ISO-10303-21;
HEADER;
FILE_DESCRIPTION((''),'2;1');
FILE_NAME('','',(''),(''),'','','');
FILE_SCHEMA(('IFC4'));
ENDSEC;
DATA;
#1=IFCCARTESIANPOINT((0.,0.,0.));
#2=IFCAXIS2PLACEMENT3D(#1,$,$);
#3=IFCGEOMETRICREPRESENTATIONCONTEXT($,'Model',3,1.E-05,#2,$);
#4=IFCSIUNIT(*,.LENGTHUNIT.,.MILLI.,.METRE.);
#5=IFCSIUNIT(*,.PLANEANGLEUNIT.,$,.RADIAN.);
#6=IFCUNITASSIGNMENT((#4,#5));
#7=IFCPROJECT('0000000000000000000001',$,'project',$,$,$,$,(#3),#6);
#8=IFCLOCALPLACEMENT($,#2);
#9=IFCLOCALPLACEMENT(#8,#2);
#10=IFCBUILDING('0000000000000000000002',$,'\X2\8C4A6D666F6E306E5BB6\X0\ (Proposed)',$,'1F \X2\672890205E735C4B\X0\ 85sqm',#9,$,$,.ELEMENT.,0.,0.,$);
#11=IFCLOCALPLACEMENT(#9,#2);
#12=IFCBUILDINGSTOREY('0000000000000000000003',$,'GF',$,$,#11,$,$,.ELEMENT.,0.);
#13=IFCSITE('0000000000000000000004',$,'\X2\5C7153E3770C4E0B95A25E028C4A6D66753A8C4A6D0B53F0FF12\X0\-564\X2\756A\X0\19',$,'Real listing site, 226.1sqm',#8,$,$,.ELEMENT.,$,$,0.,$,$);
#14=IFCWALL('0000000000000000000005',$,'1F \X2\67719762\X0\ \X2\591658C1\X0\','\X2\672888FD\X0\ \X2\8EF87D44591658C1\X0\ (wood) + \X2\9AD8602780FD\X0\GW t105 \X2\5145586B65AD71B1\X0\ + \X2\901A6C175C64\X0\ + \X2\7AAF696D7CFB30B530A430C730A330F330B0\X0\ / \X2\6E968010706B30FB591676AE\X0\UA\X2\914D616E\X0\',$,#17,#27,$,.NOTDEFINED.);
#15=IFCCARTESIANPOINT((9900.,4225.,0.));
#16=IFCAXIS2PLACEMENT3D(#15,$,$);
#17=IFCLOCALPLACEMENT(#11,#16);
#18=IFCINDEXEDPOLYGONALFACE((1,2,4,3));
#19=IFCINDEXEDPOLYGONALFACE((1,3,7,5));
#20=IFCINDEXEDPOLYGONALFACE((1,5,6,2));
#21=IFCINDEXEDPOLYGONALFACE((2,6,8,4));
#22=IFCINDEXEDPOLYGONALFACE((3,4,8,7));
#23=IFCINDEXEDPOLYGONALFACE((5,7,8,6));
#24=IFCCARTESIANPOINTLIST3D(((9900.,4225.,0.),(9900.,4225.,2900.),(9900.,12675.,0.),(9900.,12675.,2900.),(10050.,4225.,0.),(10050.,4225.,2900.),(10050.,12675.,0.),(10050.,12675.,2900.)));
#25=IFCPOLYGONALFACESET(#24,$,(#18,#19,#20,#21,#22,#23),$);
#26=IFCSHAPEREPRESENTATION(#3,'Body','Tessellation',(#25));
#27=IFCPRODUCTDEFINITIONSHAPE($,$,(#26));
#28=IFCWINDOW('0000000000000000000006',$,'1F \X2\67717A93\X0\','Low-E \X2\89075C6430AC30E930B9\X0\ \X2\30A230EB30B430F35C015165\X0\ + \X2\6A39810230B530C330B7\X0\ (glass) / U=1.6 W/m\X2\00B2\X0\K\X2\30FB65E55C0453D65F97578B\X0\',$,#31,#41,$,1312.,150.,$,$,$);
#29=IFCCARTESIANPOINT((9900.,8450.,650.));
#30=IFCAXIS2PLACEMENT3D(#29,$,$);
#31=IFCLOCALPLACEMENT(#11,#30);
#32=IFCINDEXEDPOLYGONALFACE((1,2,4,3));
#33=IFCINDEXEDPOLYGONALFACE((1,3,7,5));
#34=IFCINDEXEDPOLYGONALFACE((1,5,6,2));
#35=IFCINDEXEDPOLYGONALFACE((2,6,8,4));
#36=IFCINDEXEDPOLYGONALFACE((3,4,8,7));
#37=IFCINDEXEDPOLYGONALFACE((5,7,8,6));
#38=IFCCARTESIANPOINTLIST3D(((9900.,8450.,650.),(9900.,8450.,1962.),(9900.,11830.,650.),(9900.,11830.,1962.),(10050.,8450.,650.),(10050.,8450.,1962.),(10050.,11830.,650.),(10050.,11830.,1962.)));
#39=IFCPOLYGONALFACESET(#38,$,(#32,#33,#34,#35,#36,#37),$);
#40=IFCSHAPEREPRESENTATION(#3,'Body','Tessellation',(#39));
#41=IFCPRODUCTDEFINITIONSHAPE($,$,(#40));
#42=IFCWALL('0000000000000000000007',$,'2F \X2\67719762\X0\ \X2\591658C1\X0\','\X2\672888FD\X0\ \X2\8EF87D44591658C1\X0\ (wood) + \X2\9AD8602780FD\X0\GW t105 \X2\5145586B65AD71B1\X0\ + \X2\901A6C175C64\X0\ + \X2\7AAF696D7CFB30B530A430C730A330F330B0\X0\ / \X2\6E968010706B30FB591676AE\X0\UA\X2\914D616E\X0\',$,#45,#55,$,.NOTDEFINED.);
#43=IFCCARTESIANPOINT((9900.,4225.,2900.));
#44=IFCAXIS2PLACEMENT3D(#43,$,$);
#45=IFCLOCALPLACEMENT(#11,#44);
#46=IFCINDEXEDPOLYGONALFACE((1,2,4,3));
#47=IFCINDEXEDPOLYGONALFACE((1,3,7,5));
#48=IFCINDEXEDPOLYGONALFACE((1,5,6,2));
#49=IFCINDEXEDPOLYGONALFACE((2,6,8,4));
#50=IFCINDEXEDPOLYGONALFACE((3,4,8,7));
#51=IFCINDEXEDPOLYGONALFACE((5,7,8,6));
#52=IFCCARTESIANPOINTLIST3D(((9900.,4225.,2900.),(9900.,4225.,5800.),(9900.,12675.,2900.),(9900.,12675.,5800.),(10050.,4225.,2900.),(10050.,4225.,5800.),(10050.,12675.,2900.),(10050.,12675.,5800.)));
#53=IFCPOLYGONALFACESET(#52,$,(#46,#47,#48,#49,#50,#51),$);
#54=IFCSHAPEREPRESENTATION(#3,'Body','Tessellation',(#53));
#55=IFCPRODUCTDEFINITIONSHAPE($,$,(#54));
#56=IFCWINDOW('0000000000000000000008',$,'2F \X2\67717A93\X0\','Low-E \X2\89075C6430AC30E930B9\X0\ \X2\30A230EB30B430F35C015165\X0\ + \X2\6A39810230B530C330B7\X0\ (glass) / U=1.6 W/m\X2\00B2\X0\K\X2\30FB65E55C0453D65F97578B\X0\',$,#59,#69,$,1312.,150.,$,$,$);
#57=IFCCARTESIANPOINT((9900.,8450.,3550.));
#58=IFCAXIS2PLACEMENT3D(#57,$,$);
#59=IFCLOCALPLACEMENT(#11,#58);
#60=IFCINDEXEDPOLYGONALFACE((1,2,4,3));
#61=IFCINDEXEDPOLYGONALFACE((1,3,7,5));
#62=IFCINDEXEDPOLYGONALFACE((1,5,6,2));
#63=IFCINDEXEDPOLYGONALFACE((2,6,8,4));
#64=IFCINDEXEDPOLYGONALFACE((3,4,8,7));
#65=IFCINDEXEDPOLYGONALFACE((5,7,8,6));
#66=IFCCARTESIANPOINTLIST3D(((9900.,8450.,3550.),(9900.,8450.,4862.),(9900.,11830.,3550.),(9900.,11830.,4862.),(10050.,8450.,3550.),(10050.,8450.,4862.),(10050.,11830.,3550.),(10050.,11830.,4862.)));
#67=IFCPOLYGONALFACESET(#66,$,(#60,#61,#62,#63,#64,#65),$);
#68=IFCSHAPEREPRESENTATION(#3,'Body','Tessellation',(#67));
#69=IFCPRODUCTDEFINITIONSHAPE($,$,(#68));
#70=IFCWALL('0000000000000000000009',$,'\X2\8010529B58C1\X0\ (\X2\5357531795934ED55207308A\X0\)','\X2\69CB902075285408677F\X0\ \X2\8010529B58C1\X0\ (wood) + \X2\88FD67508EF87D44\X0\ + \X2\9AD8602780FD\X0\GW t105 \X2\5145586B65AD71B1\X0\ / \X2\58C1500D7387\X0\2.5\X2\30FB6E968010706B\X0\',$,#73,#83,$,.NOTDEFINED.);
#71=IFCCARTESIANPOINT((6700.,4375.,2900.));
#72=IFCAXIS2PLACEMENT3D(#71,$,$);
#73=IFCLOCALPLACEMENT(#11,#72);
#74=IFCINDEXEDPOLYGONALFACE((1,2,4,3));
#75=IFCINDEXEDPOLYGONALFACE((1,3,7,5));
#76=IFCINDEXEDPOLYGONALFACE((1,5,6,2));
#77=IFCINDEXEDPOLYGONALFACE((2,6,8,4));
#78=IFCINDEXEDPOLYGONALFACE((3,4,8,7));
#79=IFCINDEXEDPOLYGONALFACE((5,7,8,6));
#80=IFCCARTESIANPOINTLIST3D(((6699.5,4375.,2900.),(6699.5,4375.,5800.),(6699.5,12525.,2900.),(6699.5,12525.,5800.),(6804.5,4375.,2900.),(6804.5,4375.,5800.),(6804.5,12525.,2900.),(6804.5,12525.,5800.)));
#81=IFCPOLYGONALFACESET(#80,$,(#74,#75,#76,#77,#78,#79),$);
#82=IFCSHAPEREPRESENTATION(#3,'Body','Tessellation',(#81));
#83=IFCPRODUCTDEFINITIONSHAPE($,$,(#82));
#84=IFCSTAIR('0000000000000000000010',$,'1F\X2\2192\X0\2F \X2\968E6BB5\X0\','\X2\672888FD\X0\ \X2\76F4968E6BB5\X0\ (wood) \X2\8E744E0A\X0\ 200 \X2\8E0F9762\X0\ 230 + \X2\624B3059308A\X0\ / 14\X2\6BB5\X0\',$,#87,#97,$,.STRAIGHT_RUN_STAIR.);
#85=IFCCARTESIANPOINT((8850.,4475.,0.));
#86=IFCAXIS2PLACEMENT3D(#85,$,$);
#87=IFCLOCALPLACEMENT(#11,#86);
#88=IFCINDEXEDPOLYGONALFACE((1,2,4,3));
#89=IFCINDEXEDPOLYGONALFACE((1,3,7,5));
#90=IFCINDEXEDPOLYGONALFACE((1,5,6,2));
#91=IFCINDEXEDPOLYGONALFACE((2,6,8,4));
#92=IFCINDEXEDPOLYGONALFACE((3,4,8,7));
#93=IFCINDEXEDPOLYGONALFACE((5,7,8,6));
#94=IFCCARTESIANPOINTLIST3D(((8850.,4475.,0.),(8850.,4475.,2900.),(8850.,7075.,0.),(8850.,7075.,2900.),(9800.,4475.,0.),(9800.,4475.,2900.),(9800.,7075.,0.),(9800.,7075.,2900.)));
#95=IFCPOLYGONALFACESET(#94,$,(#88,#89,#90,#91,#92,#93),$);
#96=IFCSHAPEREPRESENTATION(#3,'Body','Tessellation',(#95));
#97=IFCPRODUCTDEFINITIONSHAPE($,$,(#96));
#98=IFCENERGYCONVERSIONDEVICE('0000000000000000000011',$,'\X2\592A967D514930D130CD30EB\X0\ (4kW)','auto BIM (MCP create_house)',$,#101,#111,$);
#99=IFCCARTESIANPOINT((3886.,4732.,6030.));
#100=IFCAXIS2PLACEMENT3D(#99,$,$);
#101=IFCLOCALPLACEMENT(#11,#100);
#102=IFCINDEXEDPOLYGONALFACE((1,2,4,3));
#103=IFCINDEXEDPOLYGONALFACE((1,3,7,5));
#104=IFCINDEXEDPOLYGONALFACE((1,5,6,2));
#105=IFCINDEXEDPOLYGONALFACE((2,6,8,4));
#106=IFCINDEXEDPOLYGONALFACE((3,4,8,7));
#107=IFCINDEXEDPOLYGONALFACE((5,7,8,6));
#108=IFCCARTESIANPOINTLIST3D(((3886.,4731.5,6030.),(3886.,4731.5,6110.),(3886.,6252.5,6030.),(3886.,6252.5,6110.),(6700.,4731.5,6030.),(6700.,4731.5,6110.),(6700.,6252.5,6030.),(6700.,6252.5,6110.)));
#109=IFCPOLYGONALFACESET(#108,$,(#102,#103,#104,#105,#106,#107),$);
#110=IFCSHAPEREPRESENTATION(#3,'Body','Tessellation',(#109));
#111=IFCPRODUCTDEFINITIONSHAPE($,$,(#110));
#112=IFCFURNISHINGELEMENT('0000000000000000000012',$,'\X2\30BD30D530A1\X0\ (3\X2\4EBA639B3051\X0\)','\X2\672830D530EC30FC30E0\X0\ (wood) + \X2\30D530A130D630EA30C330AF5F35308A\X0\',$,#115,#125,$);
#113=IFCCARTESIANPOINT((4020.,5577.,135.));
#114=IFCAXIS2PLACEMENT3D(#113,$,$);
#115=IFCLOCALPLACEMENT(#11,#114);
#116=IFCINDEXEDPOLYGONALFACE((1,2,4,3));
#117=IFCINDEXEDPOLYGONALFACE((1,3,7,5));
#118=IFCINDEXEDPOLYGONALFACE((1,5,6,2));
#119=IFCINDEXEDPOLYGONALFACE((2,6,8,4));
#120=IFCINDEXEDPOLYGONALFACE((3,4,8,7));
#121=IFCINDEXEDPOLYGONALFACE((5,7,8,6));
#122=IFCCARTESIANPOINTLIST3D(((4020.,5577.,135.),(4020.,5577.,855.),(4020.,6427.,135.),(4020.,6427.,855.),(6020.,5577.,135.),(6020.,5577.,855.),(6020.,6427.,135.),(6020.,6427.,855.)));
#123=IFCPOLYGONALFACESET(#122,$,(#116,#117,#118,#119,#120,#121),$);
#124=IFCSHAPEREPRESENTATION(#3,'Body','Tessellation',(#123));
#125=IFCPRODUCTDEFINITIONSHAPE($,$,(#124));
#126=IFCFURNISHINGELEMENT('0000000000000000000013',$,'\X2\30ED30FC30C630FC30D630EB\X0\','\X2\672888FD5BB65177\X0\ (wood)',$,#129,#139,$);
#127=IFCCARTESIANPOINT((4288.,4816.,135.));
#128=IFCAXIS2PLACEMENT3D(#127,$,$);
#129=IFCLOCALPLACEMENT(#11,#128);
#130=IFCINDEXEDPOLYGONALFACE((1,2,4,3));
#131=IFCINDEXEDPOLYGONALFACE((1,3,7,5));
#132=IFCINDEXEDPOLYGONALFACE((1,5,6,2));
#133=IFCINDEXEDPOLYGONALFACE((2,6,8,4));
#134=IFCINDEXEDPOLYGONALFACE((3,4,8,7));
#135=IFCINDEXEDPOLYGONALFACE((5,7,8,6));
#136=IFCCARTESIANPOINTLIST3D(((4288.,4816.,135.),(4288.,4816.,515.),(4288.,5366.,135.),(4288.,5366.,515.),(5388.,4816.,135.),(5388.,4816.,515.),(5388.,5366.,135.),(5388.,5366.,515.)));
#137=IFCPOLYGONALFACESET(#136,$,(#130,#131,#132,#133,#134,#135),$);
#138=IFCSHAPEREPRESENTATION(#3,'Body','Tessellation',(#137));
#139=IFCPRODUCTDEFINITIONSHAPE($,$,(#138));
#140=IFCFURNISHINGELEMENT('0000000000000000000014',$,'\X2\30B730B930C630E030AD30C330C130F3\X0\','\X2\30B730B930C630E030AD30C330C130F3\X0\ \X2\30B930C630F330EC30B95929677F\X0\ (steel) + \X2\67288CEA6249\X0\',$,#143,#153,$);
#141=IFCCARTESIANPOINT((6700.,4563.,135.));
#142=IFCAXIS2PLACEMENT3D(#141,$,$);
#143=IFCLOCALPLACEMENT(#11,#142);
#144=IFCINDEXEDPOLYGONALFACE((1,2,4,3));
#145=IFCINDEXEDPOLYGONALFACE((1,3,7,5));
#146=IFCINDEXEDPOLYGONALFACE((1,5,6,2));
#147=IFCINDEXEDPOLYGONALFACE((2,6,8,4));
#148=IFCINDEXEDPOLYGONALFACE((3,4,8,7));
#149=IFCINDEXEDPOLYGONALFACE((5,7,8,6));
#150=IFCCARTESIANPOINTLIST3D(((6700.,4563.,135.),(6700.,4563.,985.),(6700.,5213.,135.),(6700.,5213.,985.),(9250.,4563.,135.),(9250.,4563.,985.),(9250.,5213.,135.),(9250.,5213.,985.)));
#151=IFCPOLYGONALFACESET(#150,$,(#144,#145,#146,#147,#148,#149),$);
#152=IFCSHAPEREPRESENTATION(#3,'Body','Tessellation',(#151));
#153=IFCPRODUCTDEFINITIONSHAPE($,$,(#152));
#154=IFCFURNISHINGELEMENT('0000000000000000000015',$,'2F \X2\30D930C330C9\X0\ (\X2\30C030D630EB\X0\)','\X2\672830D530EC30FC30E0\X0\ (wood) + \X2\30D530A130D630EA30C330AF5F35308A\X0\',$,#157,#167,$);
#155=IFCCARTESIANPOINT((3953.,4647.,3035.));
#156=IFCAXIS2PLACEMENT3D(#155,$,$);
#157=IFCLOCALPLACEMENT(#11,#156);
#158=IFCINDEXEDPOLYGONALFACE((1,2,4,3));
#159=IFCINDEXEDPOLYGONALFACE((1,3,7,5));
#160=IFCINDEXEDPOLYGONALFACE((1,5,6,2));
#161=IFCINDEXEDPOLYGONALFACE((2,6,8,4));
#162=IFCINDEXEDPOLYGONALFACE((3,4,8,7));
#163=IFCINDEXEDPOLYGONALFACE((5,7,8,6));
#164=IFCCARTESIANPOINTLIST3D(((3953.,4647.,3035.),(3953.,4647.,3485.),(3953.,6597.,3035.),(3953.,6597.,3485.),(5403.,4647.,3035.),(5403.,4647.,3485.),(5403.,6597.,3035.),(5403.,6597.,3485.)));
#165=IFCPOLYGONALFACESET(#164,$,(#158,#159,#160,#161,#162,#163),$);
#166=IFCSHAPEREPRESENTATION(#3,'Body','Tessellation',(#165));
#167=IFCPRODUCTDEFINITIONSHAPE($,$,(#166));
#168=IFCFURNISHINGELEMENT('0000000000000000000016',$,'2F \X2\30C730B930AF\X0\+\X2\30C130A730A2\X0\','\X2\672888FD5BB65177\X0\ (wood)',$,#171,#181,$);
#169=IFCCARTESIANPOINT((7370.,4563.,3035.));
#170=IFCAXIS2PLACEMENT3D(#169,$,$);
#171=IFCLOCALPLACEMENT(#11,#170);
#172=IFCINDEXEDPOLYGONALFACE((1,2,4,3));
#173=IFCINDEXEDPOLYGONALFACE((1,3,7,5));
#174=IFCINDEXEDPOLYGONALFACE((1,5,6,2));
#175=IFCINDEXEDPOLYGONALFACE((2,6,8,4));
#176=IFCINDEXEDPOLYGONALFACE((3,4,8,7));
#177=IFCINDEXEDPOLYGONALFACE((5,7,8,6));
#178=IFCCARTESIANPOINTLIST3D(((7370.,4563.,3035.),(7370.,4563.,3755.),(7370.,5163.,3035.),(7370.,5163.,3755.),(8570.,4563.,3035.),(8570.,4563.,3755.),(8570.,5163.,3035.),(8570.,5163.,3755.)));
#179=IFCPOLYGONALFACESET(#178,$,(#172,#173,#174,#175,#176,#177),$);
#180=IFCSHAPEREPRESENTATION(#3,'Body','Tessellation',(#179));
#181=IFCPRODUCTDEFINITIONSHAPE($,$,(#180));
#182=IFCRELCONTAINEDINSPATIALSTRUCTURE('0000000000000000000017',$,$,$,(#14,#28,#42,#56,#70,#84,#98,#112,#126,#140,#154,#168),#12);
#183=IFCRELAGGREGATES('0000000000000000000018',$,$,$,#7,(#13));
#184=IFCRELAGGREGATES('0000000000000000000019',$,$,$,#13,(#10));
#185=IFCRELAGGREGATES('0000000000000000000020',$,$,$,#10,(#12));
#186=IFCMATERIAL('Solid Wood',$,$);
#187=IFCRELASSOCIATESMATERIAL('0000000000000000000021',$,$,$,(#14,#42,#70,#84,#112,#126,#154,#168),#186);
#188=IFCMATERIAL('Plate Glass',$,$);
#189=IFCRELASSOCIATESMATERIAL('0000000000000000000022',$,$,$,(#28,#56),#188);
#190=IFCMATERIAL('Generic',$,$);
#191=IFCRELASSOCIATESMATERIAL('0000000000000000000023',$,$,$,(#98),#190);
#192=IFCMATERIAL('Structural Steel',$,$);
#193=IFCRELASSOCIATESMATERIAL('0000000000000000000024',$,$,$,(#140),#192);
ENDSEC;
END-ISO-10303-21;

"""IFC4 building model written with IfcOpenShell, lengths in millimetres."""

from ifc_helpers import new_model, si_unit, frame, frame_2d, origin, place, context, project, spatial, rectangle, extrude, material, element, fill, save


model = new_model("IFC4")

# Units and contexts
model_context = context("Model", 3, precision=1e-05, world=origin())
ifc_project = project(units=[si_unit("LENGTHUNIT", "METRE", prefix="MILLI"), si_unit("PLANEANGLEUNIT", "RADIAN")], contexts=[model_context])

# Site, building, storey
site_placement = place(None, origin())
site = spatial("IfcSite", under=ifc_project, at=site_placement, Name="山口県下関市豊浦町豊洋台２-564番19", ObjectType="Real listing site, 226.1sqm", CompositionType="ELEMENT", RefElevation=0.0)
building_placement = place(site_placement, origin())
building = spatial("IfcBuilding", under=site, at=building_placement, Name="豊浦潮の家 (Proposed)", ObjectType="1F 木造平屋 85sqm", CompositionType="ELEMENT", ElevationOfRefHeight=0.0, ElevationOfTerrain=0.0)
storey_placement = place(building_placement, origin())
storey = spatial("IfcBuildingStorey", under=building, at=storey_placement, Name="GF", CompositionType="ELEMENT", Elevation=0.0)

# Wall, opening, window
ifc_material_1 = material(Name="Solid Wood")
wall_1_placement = place(storey_placement, frame((9900.0, 4225.0, 0.0)))
wall_1 = element("IfcWall", 1, at=wall_1_placement, inside=storey, material=ifc_material_1, Name="1F 東面 外壁", Description="木製 軸組外壁 (wood) + 高性能GW t105 充填断熱 + 通気層 + 窯業系サイディング / 準耐火・外皮UA配慮", PredefinedType="NOTDEFINED", context=model_context, shape_type="SweptSolid", body=[
    extrude(rectangle(XDim=150.0, YDim=8450.0, at=frame_2d((75.0, 4225.0))), frame((9900.0, 4225.0, 0.0)), (0.0, 0.0, 1.0), 2900.0),
])
opening_1_placement = place(storey_placement, frame((9900.0, 8450.0, 650.0)))
opening_1 = element("IfcOpeningElement", 2, at=opening_1_placement, cuts=wall_1, PredefinedType="NOTDEFINED", context=model_context, shape_type="SweptSolid", body=[
    extrude(rectangle(XDim=150.0, YDim=3380.0, at=frame_2d((75.0, 1690.0))), frame((9900.0, 8450.0, 650.0)), (0.0, 0.0, 1.0), 1312.0),
])
ifc_material_2 = material(Name="Plate Glass")
window_1_placement = place(storey_placement, frame((9900.0, 8450.0, 650.0)))
window_1 = element("IfcWindow", 3, at=window_1_placement, inside=storey, material=ifc_material_2, Name="1F 東窓", Description="Low-E 複層ガラス アルゴン封入 + 樹脂サッシ (glass) / U=1.6 W/m²K・日射取得型", OverallHeight=1312.0, OverallWidth=150.0, context=model_context, shape_type="SweptSolid", body=[
    extrude(rectangle(XDim=150.0, YDim=3380.0, at=frame_2d((75.0, 1690.0))), frame((9900.0, 8450.0, 650.0)), (0.0, 0.0, 1.0), 1312.0),
])
fill(opening_1, window_1)

# Wall, opening, window
wall_2_placement = place(storey_placement, frame((9900.0, 4225.0, 2900.0)))
wall_2 = element("IfcWall", 4, at=wall_2_placement, inside=storey, material=ifc_material_1, Name="2F 東面 外壁", Description="木製 軸組外壁 (wood) + 高性能GW t105 充填断熱 + 通気層 + 窯業系サイディング / 準耐火・外皮UA配慮", PredefinedType="NOTDEFINED", context=model_context, shape_type="SweptSolid", body=[
    extrude(rectangle(XDim=150.0, YDim=8450.0, at=frame_2d((75.0, 4225.0))), frame((9900.0, 4225.0, 2900.0)), (0.0, 0.0, 1.0), 2900.0),
])
opening_2_placement = place(storey_placement, frame((9900.0, 8450.0, 3550.0)))
opening_2 = element("IfcOpeningElement", 5, at=opening_2_placement, cuts=wall_2, PredefinedType="NOTDEFINED", context=model_context, shape_type="SweptSolid", body=[
    extrude(rectangle(XDim=150.0, YDim=3380.0, at=frame_2d((75.0, 1690.0))), frame((9900.0, 8450.0, 3550.0)), (0.0, 0.0, 1.0), 1312.0),
])
window_2_placement = place(storey_placement, frame((9900.0, 8450.0, 3550.0)))
window_2 = element("IfcWindow", 6, at=window_2_placement, inside=storey, material=ifc_material_2, Name="2F 東窓", Description="Low-E 複層ガラス アルゴン封入 + 樹脂サッシ (glass) / U=1.6 W/m²K・日射取得型", OverallHeight=1312.0, OverallWidth=150.0, context=model_context, shape_type="SweptSolid", body=[
    extrude(rectangle(XDim=150.0, YDim=3380.0, at=frame_2d((75.0, 1690.0))), frame((9900.0, 8450.0, 3550.0)), (0.0, 0.0, 1.0), 1312.0),
])
fill(opening_2, window_2)

# Wall
wall_3_placement = place(storey_placement, frame((6700.0, 4375.0, 2900.0)))
element("IfcWall", 7, at=wall_3_placement, inside=storey, material=ifc_material_1, Name="耐力壁 (南北間仕切り)", Description="構造用合板 耐力壁 (wood) + 製材軸組 + 高性能GW t105 充填断熱 / 壁倍率2.5・準耐火", PredefinedType="NOTDEFINED", context=model_context, shape_type="SweptSolid", body=[
    extrude(rectangle(XDim=105.0, YDim=8150.0, at=frame_2d((52.0, 4075.0))), frame((6700.0, 4375.0, 2900.0)), (0.0, 0.0, 1.0), 2900.0),
])

# Stair
stair_placement = place(storey_placement, frame((8850.0, 4475.0, 0.0)))
element("IfcStair", 8, at=stair_placement, inside=storey, material=ifc_material_1, Name="1F→2F 階段", Description="木製 直階段 (wood) 蹴上 200 踏面 230 + 手すり / 14段", PredefinedType="STRAIGHT_RUN_STAIR", context=model_context, shape_type="SweptSolid", body=[
    extrude(rectangle(XDim=950.0, YDim=2600.0, at=frame_2d((475.0, 1300.0))), frame((8850.0, 4475.0, 0.0)), (0.0, 0.0, 1.0), 2900.0),
])

# Energy conversion device
ifc_material_3 = material(Name="Generic")
energy_conversion_device_placement = place(storey_placement, frame((3886.0, 4732.0, 6030.0)))
element("IfcEnergyConversionDevice", 9, at=energy_conversion_device_placement, inside=storey, material=ifc_material_3, Name="太陽光パネル (4kW)", Description="auto BIM (MCP create_house)", context=model_context, shape_type="SweptSolid", body=[
    extrude(rectangle(XDim=2814.0, YDim=1521.0, at=frame_2d((1407.0, 760.0))), frame((3886.0, 4732.0, 6030.0)), (0.0, 0.0, 1.0), 80.0),
])

# Furnishing elements
furnishing_1_placement = place(storey_placement, frame((4020.0, 5577.0, 135.0)))
element("IfcFurnishingElement", 10, at=furnishing_1_placement, inside=storey, material=ifc_material_1, Name="ソファ (3人掛け)", Description="木フレーム (wood) + ファブリック張り", context=model_context, shape_type="SweptSolid", body=[
    extrude(rectangle(XDim=2000.0, YDim=850.0, at=frame_2d((1000.0, 425.0))), frame((4020.0, 5577.0, 135.0)), (0.0, 0.0, 1.0), 720.0),
])
furnishing_2_placement = place(storey_placement, frame((4288.0, 4816.0, 135.0)))
element("IfcFurnishingElement", 11, at=furnishing_2_placement, inside=storey, material=ifc_material_1, Name="ローテーブル", Description="木製家具 (wood)", context=model_context, shape_type="SweptSolid", body=[
    extrude(rectangle(XDim=1100.0, YDim=550.0, at=frame_2d((550.0, 275.0))), frame((4288.0, 4816.0, 135.0)), (0.0, 0.0, 1.0), 380.0),
])
ifc_material_4 = material(Name="Structural Steel")
furnishing_3_placement = place(storey_placement, frame((6700.0, 4563.0, 135.0)))
element("IfcFurnishingElement", 12, at=furnishing_3_placement, inside=storey, material=ifc_material_4, Name="システムキッチン", Description="システムキッチン ステンレス天板 (steel) + 木質扉", context=model_context, shape_type="SweptSolid", body=[
    extrude(rectangle(XDim=2550.0, YDim=650.0, at=frame_2d((1275.0, 325.0))), frame((6700.0, 4563.0, 135.0)), (0.0, 0.0, 1.0), 850.0),
])
furnishing_4_placement = place(storey_placement, frame((3953.0, 4647.0, 3035.0)))
element("IfcFurnishingElement", 13, at=furnishing_4_placement, inside=storey, material=ifc_material_1, Name="2F ベッド (ダブル)", Description="木フレーム (wood) + ファブリック張り", context=model_context, shape_type="SweptSolid", body=[
    extrude(rectangle(XDim=1450.0, YDim=1950.0, at=frame_2d((725.0, 975.0))), frame((3953.0, 4647.0, 3035.0)), (0.0, 0.0, 1.0), 450.0),
])
furnishing_5_placement = place(storey_placement, frame((7370.0, 4563.0, 3035.0)))
element("IfcFurnishingElement", 14, at=furnishing_5_placement, inside=storey, material=ifc_material_1, Name="2F デスク+チェア", Description="木製家具 (wood)", context=model_context, shape_type="SweptSolid", body=[
    extrude(rectangle(XDim=1200.0, YDim=600.0, at=frame_2d((600.0, 300.0))), frame((7370.0, 4563.0, 3035.0)), (0.0, 0.0, 1.0), 720.0),
])

save(model, "model.ifc")
